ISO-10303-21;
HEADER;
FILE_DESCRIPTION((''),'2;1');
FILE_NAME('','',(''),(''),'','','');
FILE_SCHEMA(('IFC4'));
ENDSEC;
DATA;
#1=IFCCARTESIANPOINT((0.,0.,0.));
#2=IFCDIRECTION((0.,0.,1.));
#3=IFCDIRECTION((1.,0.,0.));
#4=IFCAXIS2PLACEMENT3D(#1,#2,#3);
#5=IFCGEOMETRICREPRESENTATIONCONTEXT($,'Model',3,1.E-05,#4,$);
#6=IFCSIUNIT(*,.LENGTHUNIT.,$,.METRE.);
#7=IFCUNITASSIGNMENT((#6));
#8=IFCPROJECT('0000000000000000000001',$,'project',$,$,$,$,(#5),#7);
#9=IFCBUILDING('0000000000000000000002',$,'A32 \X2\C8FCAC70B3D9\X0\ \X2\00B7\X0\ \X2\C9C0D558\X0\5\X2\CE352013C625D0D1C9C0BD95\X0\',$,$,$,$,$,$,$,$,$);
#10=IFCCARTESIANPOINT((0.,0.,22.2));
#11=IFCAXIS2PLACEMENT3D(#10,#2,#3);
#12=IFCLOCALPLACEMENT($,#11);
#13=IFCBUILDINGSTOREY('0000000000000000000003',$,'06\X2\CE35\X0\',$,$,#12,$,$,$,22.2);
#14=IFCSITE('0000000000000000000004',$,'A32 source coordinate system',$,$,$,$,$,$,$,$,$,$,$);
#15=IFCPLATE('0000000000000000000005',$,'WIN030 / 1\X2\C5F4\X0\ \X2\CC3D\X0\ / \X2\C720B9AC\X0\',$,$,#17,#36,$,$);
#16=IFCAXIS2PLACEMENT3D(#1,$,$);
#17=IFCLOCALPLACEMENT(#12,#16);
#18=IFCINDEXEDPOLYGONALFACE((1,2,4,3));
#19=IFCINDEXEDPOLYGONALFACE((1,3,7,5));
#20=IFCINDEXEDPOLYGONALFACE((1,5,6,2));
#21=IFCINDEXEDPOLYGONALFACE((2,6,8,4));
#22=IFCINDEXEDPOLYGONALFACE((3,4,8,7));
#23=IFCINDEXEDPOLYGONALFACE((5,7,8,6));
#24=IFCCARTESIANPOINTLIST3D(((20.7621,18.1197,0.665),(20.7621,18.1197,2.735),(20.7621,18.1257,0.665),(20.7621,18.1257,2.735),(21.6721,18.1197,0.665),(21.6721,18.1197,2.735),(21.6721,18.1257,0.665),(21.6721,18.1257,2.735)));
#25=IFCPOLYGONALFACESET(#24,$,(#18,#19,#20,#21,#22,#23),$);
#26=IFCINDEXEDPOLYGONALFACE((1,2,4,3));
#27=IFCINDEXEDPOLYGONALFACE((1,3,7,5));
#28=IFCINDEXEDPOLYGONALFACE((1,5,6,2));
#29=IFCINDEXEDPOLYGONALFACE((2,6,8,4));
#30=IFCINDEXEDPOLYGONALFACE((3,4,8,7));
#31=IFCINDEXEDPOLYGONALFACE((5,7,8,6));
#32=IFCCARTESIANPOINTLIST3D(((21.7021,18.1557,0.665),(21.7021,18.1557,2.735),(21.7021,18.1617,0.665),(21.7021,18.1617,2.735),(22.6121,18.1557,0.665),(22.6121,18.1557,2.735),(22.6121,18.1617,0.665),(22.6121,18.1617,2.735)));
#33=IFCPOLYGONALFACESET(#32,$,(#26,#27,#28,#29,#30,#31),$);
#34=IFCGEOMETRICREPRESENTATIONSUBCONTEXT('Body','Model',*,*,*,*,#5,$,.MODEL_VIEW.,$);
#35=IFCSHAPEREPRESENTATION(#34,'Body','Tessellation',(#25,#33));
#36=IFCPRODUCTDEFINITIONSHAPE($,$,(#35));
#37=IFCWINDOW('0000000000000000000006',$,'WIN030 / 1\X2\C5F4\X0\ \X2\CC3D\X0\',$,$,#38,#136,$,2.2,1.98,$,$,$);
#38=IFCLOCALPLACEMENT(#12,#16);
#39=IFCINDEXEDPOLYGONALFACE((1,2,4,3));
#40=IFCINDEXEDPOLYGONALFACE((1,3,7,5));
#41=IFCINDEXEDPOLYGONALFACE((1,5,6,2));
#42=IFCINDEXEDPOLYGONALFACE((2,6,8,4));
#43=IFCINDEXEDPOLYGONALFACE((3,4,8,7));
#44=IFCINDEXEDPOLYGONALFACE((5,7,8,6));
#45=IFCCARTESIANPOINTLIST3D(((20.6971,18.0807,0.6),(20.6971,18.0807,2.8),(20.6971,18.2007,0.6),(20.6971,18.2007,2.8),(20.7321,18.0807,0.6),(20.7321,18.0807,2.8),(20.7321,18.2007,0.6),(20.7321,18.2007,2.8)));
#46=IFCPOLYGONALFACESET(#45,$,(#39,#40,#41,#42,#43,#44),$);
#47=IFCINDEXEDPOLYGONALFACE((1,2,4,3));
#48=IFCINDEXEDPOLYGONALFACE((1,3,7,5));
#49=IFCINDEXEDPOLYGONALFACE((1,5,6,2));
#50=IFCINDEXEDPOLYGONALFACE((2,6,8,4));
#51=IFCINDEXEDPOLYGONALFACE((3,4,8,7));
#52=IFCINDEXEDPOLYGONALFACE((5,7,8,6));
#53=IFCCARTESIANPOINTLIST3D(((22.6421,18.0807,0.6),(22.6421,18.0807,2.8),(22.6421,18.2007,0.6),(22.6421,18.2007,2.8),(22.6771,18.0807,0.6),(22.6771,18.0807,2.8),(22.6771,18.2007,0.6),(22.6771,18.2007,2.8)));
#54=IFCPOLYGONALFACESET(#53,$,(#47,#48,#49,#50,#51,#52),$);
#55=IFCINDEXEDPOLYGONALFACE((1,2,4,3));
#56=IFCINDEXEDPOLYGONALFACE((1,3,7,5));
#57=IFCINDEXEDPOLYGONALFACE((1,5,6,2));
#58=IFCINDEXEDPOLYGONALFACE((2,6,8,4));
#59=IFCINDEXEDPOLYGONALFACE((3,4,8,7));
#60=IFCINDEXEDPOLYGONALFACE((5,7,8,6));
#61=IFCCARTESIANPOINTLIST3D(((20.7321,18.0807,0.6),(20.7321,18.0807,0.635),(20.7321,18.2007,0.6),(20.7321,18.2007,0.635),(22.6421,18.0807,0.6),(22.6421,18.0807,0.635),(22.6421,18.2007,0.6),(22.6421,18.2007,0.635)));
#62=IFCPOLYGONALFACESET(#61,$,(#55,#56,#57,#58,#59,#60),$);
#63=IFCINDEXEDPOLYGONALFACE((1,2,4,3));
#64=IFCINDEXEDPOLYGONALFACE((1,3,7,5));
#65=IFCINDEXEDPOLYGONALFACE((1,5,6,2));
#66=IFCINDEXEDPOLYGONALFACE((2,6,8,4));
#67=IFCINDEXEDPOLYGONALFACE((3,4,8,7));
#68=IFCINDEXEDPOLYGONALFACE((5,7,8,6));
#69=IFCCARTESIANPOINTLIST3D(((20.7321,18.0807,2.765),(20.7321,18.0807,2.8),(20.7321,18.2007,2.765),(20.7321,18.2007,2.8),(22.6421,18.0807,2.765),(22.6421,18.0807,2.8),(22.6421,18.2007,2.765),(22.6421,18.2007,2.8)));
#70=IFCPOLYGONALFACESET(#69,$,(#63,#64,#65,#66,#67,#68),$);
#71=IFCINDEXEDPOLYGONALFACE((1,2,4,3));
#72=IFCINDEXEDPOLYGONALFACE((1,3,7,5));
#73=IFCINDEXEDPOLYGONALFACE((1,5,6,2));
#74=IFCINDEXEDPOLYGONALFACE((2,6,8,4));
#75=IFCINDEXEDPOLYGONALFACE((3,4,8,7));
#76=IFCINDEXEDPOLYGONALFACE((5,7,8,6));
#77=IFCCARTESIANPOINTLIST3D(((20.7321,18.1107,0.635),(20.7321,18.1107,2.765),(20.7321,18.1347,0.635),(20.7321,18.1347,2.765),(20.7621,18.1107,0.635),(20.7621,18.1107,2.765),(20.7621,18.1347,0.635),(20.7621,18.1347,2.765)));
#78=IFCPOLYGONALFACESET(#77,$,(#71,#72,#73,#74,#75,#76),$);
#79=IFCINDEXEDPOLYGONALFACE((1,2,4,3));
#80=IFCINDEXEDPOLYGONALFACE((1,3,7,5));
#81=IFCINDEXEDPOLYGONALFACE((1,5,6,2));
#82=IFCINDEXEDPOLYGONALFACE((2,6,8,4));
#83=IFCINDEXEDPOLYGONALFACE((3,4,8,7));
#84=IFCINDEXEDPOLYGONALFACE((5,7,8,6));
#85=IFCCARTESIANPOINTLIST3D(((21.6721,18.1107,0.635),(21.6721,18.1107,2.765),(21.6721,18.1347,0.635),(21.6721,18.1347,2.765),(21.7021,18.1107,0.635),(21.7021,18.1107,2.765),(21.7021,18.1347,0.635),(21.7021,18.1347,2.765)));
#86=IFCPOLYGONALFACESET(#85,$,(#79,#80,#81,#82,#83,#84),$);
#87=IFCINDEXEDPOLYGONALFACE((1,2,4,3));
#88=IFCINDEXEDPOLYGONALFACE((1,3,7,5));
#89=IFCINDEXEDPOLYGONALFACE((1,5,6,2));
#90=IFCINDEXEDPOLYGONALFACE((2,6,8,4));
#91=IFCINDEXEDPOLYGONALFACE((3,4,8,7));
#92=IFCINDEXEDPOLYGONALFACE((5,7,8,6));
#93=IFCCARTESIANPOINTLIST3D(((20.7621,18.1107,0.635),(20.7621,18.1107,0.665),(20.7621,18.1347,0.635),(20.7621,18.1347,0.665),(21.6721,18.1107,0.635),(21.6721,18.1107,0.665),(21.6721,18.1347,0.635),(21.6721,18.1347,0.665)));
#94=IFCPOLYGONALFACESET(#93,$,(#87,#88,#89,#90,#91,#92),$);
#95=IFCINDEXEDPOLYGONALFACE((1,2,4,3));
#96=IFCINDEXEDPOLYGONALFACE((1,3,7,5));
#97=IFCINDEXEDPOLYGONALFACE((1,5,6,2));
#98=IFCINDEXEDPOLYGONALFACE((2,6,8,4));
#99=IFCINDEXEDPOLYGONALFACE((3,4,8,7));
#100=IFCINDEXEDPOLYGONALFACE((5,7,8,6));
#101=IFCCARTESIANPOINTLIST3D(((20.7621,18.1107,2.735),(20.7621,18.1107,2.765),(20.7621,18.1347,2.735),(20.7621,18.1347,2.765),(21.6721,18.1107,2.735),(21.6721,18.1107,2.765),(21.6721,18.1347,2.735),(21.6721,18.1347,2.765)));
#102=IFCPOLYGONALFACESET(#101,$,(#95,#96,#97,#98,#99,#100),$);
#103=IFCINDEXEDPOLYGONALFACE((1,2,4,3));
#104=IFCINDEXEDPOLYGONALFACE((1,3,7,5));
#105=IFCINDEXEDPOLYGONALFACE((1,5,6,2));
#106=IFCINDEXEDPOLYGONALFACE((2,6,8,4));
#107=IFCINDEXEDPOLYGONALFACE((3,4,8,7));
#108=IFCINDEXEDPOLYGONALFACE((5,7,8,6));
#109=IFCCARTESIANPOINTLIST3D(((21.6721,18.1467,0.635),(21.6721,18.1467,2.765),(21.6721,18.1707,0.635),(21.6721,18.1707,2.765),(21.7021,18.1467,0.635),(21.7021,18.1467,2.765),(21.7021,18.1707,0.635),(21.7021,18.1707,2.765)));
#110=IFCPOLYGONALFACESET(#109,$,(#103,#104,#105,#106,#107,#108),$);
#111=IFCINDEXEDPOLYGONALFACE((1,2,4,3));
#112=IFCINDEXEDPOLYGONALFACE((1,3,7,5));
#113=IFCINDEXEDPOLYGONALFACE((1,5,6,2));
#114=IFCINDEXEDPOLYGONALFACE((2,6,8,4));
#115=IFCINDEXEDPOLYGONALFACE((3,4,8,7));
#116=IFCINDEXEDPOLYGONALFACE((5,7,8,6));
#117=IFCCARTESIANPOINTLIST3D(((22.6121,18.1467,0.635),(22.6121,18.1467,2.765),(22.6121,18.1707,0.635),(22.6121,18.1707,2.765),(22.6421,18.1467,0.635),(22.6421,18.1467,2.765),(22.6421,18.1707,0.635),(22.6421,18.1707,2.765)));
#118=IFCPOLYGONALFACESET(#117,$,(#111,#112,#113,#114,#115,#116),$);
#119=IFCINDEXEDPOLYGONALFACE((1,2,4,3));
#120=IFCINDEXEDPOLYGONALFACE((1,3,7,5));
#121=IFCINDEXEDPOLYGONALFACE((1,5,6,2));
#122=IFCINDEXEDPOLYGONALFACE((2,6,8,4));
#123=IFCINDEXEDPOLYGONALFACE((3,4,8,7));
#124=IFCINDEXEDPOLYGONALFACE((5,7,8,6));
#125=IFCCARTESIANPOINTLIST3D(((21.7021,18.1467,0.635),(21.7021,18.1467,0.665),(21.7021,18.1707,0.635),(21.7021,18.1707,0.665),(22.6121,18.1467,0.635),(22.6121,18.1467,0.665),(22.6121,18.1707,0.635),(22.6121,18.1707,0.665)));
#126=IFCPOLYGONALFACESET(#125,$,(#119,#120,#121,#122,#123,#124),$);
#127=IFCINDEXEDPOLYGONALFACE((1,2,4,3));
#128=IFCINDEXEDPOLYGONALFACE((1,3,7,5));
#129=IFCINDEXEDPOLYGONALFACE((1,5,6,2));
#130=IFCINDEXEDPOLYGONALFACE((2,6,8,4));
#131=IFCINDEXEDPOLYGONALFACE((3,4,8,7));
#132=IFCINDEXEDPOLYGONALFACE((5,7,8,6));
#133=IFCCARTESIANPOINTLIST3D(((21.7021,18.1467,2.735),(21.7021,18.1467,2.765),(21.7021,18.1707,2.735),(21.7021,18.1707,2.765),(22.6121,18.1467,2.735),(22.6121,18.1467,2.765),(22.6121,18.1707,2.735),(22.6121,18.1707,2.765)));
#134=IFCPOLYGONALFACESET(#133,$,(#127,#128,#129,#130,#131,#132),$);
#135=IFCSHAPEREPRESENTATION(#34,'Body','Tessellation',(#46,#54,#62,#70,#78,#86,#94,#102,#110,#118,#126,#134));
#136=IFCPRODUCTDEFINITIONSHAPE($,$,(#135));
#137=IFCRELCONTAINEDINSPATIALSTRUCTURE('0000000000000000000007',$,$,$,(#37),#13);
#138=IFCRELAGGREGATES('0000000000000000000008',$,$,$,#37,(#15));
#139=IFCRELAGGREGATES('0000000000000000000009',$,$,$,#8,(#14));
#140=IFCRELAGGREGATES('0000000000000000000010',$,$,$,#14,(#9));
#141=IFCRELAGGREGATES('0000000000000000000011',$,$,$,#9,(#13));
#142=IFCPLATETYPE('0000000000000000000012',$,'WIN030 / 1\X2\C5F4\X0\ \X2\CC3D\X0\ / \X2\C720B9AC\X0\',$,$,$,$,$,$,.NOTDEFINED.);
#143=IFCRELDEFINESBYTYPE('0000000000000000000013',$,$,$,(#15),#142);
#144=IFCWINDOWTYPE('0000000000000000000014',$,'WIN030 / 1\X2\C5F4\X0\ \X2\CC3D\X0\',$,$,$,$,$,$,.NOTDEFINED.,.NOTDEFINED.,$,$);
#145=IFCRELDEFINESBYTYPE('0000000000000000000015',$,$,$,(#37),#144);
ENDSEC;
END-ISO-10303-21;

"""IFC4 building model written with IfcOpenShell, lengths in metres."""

from ifc_helpers import new_model, si_unit, frame, origin, origin_with_axes, place, context, subcontext, project, spatial, polyline, outline, extrude, source, transform, mapped, type_object, type_shapes, element, aggregate, save


model = new_model("IFC4")

# Units and contexts
model_context = context("Model", 3, precision=1e-05, world=origin_with_axes())
body_context = subcontext(model_context, "Body", "Model", "MODEL_VIEW")
ifc_project = project(units=[si_unit("LENGTHUNIT", "METRE")], contexts=[model_context])

# Plate
storey_placement = place(None, frame((0.0, 0.0, 22.2), z_axis=(0.0, 0.0, 1.0), x_axis=(1.0, 0.0, 0.0)))
plate_type_1 = type_object("IfcPlateType", Name="WIN030 / 1열 창 / 유리", PredefinedType="NOTDEFINED")
shared_shape_1 = source(origin(), body_context, "Body", "SweptSolid", [
    extrude(outline(polyline([(20.7621, 18.1197), (20.7621, 18.1257), (21.6721, 18.1257), (21.6721, 18.1197), (20.7621, 18.1197)])), frame((0.0, 0.0, 0.665)), (0.0, 0.0, 1.0), 2.07),
    extrude(outline(polyline([(21.7021, 18.1557), (21.7021, 18.1617), (22.6121, 18.1617), (22.6121, 18.1557), (21.7021, 18.1557)])), frame((0.0, 0.0, 0.665)), (0.0, 0.0, 1.0), 2.07),
])
type_shapes(plate_type_1, [shared_shape_1])
window_1_placement = place(storey_placement, origin_with_axes())
plate_1_placement = place(window_1_placement, origin_with_axes())
plate_1 = element("IfcPlate", 1, at=plate_1_placement, type_object=plate_type_1, Name="WIN030 / 1열 창 / 유리", context=body_context, shape_type="MappedRepresentation", body=[
    mapped(shared_shape_1, transform((0.0, 0.0, 0.0), scale=1.0)),
])

# Site, building, storey
site = spatial("IfcSite", under=ifc_project, Name="A32 source coordinate system")
building = spatial("IfcBuilding", under=site, Name="A32 주거동 · 지하5층–옥탑지붕")
storey = spatial("IfcBuildingStorey", under=building, at=storey_placement, Name="06층", Elevation=22.2)

# Window
window_type_1 = type_object("IfcWindowType", Name="WIN030 / 1열 창", PartitioningType="NOTDEFINED", PredefinedType="NOTDEFINED")
shared_shape_2 = source(origin(), body_context, "Body", "SweptSolid", [
    extrude(outline(polyline([(20.6971, 18.0807), (20.6971, 18.2007), (20.7321, 18.2007), (20.7321, 18.0807), (20.6971, 18.0807)])), frame((0.0, 0.0, 0.6)), (0.0, 0.0, 1.0), 2.2),
    extrude(outline(polyline([(22.6421, 18.0807), (22.6421, 18.2007), (22.6771, 18.2007), (22.6771, 18.0807), (22.6421, 18.0807)])), frame((0.0, 0.0, 0.6)), (0.0, 0.0, 1.0), 2.2),
    extrude(outline(polyline([(20.7321, 18.0807), (20.7321, 18.2007), (22.6421, 18.2007), (22.6421, 18.0807), (20.7321, 18.0807)])), frame((0.0, 0.0, 0.6)), (0.0, 0.0, 1.0), 0.035),
    extrude(outline(polyline([(20.7321, 18.0807), (20.7321, 18.2007), (22.6421, 18.2007), (22.6421, 18.0807), (20.7321, 18.0807)])), frame((0.0, 0.0, 2.765)), (0.0, 0.0, 1.0), 0.035),
    extrude(outline(polyline([(20.7321, 18.1107), (20.7321, 18.1347), (20.7621, 18.1347), (20.7621, 18.1107), (20.7321, 18.1107)])), frame((0.0, 0.0, 0.635)), (0.0, 0.0, 1.0), 2.13),
    extrude(outline(polyline([(21.6721, 18.1107), (21.6721, 18.1347), (21.7021, 18.1347), (21.7021, 18.1107), (21.6721, 18.1107)])), frame((0.0, 0.0, 0.635)), (0.0, 0.0, 1.0), 2.13),
    extrude(outline(polyline([(20.7621, 18.1107), (20.7621, 18.1347), (21.6721, 18.1347), (21.6721, 18.1107), (20.7621, 18.1107)])), frame((0.0, 0.0, 0.635)), (0.0, 0.0, 1.0), 0.03),
    extrude(outline(polyline([(20.7621, 18.1107), (20.7621, 18.1347), (21.6721, 18.1347), (21.6721, 18.1107), (20.7621, 18.1107)])), frame((0.0, 0.0, 2.735)), (0.0, 0.0, 1.0), 0.03),
    extrude(outline(polyline([(21.6721, 18.1467), (21.6721, 18.1707), (21.7021, 18.1707), (21.7021, 18.1467), (21.6721, 18.1467)])), frame((0.0, 0.0, 0.635)), (0.0, 0.0, 1.0), 2.13),
    extrude(outline(polyline([(22.6121, 18.1467), (22.6121, 18.1707), (22.6421, 18.1707), (22.6421, 18.1467), (22.6121, 18.1467)])), frame((0.0, 0.0, 0.635)), (0.0, 0.0, 1.0), 2.13),
    extrude(outline(polyline([(21.7021, 18.1467), (21.7021, 18.1707), (22.6121, 18.1707), (22.6121, 18.1467), (21.7021, 18.1467)])), frame((0.0, 0.0, 0.635)), (0.0, 0.0, 1.0), 0.03),
    extrude(outline(polyline([(21.7021, 18.1467), (21.7021, 18.1707), (22.6121, 18.1707), (22.6121, 18.1467), (21.7021, 18.1467)])), frame((0.0, 0.0, 2.735)), (0.0, 0.0, 1.0), 0.03),
])
type_shapes(window_type_1, [shared_shape_2])
window_1 = element("IfcWindow", 2, at=window_1_placement, inside=storey, type_object=window_type_1, Name="WIN030 / 1열 창", OverallHeight=2.2, OverallWidth=1.98, context=body_context, shape_type="MappedRepresentation", body=[
    mapped(shared_shape_2, transform((0.0, 0.0, 0.0), scale=1.0)),
])
aggregate(window_1, [plate_1])

save(model, "model.ifc")
